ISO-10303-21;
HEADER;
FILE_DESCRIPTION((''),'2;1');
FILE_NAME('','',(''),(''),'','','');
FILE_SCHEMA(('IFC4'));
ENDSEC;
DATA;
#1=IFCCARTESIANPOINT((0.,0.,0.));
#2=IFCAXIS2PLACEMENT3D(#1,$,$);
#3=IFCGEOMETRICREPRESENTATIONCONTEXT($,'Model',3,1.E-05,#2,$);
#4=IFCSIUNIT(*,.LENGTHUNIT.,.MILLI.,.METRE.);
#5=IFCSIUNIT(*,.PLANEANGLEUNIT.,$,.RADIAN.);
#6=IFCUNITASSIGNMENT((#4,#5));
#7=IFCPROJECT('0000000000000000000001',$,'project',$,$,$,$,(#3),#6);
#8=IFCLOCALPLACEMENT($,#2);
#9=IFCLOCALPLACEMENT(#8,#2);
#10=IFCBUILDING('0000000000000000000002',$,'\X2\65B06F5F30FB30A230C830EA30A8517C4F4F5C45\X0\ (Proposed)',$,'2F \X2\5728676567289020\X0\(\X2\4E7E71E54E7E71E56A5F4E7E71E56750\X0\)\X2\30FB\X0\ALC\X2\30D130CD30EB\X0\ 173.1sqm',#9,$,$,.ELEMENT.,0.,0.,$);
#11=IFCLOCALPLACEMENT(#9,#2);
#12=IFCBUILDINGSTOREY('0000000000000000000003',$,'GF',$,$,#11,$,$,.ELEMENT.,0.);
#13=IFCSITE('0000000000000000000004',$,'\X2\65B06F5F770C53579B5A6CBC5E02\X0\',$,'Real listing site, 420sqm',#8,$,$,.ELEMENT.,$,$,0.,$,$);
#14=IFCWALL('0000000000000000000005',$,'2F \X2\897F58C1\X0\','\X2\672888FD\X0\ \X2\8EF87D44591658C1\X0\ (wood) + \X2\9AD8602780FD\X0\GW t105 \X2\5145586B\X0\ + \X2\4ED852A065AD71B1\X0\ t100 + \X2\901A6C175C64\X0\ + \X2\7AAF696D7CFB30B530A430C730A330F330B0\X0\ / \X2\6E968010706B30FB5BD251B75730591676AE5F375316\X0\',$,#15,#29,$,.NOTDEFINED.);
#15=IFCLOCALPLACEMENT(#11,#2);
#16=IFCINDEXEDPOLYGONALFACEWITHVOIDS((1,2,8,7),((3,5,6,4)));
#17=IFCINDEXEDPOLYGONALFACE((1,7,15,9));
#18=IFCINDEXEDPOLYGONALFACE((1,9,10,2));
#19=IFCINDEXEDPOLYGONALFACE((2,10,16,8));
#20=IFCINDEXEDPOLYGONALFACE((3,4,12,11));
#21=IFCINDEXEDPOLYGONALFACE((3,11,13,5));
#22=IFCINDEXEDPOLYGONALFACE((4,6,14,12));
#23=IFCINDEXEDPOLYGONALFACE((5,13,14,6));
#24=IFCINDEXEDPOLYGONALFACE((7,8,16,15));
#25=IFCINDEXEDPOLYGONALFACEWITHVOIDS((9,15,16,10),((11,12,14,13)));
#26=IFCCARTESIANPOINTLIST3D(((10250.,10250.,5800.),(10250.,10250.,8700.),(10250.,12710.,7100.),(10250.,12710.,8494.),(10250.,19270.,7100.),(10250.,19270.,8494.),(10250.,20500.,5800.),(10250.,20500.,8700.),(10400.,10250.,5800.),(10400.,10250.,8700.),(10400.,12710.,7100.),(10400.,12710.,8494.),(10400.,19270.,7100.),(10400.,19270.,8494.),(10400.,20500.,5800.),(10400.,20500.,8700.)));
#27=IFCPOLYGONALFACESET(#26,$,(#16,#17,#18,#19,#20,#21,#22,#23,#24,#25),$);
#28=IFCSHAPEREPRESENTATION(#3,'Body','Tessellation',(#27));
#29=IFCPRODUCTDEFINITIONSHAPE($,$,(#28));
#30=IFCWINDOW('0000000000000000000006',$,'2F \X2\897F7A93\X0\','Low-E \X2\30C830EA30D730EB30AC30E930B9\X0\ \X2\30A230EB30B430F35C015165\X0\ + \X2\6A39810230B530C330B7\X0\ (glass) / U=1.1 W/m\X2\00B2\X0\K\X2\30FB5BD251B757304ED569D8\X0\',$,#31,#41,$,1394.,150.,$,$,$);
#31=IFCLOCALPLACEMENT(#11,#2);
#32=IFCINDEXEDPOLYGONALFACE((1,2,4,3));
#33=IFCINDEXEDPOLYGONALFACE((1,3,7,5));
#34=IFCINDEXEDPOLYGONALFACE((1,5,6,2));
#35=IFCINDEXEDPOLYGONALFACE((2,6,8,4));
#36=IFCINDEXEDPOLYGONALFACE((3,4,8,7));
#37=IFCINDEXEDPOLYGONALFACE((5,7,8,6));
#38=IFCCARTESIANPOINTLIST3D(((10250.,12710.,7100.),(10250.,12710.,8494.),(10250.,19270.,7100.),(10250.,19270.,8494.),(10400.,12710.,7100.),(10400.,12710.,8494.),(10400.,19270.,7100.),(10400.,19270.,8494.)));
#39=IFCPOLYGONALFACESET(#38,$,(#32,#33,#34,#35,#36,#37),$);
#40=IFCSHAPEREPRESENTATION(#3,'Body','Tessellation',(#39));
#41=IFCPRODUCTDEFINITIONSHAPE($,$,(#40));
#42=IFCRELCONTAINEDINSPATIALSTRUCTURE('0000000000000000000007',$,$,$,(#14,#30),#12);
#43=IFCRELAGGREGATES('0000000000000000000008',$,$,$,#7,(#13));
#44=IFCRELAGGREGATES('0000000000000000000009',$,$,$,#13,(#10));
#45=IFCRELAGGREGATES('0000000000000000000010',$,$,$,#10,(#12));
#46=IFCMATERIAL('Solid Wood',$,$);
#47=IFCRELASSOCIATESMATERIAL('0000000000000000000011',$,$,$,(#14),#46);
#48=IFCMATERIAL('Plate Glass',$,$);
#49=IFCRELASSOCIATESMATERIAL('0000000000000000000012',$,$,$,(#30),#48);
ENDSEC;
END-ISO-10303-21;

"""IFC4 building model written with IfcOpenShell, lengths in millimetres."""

from ifc_helpers import new_model, si_unit, frame, frame_2d, origin, place, context, project, spatial, rectangle, extrude, material, element, fill, save


model = new_model("IFC4")

# Units and contexts
model_context = context("Model", 3, precision=1e-05, world=origin())
ifc_project = project(units=[si_unit("LENGTHUNIT", "METRE", prefix="MILLI"), si_unit("PLANEANGLEUNIT", "RADIAN")], contexts=[model_context])

# Site, building, storey
site_placement = place(None, origin())
site = spatial("IfcSite", under=ifc_project, at=site_placement, Name="新潟県南魚沼市", ObjectType="Real listing site, 420sqm", CompositionType="ELEMENT", RefElevation=0.0)
building_placement = place(site_placement, origin())
building = spatial("IfcBuilding", under=site, at=building_placement, Name="新潟・アトリエ兼住居 (Proposed)", ObjectType="2F 在来木造(乾燥乾燥機乾燥材)・ALCパネル 173.1sqm", CompositionType="ELEMENT", ElevationOfRefHeight=0.0, ElevationOfTerrain=0.0)
storey_placement = place(building_placement, origin())
storey = spatial("IfcBuildingStorey", under=building, at=storey_placement, Name="GF", CompositionType="ELEMENT", Elevation=0.0)

# Shared definitions
ifc_material_1 = material(Name="Solid Wood")

# Shared definitions
ifc_material_2 = material(Name="Plate Glass")

# Wall, opening, window
wall_1_placement = place(storey_placement, frame((5125.0, 5125.0, 2900.0)))
wall_1 = element("IfcWall", 1, at=wall_1_placement, inside=storey, material=ifc_material_1, Name="2F 西壁", Description="木製 軸組外壁 (wood) + 高性能GW t105 充填 + 付加断熱 t100 + 通気層 + 窯業系サイディング / 準耐火・寒冷地外皮強化", PredefinedType="NOTDEFINED", context=model_context, shape_type="SweptSolid", body=[
    extrude(rectangle(XDim=150.0, YDim=10250.0, at=frame_2d((75.0, 5125.0))), frame((5125.0, 5125.0, 2900.0)), (0.0, 0.0, 1.0), 2900.0),
])
opening_1_placement = place(storey_placement, frame((5125.0, 6355.0, 3550.0)))
opening_1 = element("IfcOpeningElement", 2, at=opening_1_placement, cuts=wall_1, PredefinedType="NOTDEFINED", context=model_context, shape_type="SweptSolid", body=[
    extrude(rectangle(XDim=150.0, YDim=6560.0, at=frame_2d((75.0, 3280.0))), frame((5125.0, 6355.0, 3550.0)), (0.0, 0.0, 1.0), 1394.0),
])
window_1_placement = place(storey_placement, frame((5125.0, 6355.0, 3550.0)))
window_1 = element("IfcWindow", 3, at=window_1_placement, inside=storey, material=ifc_material_2, Name="2F 西窓", Description="Low-E トリプルガラス アルゴン封入 + 樹脂サッシ (glass) / U=1.1 W/m²K・寒冷地仕様", OverallHeight=1394.0, OverallWidth=150.0, context=model_context, shape_type="SweptSolid", body=[
    extrude(rectangle(XDim=150.0, YDim=6560.0, at=frame_2d((75.0, 3280.0))), frame((5125.0, 6355.0, 3550.0)), (0.0, 0.0, 1.0), 1394.0),
])
fill(opening_1, window_1)

save(model, "model.ifc")
